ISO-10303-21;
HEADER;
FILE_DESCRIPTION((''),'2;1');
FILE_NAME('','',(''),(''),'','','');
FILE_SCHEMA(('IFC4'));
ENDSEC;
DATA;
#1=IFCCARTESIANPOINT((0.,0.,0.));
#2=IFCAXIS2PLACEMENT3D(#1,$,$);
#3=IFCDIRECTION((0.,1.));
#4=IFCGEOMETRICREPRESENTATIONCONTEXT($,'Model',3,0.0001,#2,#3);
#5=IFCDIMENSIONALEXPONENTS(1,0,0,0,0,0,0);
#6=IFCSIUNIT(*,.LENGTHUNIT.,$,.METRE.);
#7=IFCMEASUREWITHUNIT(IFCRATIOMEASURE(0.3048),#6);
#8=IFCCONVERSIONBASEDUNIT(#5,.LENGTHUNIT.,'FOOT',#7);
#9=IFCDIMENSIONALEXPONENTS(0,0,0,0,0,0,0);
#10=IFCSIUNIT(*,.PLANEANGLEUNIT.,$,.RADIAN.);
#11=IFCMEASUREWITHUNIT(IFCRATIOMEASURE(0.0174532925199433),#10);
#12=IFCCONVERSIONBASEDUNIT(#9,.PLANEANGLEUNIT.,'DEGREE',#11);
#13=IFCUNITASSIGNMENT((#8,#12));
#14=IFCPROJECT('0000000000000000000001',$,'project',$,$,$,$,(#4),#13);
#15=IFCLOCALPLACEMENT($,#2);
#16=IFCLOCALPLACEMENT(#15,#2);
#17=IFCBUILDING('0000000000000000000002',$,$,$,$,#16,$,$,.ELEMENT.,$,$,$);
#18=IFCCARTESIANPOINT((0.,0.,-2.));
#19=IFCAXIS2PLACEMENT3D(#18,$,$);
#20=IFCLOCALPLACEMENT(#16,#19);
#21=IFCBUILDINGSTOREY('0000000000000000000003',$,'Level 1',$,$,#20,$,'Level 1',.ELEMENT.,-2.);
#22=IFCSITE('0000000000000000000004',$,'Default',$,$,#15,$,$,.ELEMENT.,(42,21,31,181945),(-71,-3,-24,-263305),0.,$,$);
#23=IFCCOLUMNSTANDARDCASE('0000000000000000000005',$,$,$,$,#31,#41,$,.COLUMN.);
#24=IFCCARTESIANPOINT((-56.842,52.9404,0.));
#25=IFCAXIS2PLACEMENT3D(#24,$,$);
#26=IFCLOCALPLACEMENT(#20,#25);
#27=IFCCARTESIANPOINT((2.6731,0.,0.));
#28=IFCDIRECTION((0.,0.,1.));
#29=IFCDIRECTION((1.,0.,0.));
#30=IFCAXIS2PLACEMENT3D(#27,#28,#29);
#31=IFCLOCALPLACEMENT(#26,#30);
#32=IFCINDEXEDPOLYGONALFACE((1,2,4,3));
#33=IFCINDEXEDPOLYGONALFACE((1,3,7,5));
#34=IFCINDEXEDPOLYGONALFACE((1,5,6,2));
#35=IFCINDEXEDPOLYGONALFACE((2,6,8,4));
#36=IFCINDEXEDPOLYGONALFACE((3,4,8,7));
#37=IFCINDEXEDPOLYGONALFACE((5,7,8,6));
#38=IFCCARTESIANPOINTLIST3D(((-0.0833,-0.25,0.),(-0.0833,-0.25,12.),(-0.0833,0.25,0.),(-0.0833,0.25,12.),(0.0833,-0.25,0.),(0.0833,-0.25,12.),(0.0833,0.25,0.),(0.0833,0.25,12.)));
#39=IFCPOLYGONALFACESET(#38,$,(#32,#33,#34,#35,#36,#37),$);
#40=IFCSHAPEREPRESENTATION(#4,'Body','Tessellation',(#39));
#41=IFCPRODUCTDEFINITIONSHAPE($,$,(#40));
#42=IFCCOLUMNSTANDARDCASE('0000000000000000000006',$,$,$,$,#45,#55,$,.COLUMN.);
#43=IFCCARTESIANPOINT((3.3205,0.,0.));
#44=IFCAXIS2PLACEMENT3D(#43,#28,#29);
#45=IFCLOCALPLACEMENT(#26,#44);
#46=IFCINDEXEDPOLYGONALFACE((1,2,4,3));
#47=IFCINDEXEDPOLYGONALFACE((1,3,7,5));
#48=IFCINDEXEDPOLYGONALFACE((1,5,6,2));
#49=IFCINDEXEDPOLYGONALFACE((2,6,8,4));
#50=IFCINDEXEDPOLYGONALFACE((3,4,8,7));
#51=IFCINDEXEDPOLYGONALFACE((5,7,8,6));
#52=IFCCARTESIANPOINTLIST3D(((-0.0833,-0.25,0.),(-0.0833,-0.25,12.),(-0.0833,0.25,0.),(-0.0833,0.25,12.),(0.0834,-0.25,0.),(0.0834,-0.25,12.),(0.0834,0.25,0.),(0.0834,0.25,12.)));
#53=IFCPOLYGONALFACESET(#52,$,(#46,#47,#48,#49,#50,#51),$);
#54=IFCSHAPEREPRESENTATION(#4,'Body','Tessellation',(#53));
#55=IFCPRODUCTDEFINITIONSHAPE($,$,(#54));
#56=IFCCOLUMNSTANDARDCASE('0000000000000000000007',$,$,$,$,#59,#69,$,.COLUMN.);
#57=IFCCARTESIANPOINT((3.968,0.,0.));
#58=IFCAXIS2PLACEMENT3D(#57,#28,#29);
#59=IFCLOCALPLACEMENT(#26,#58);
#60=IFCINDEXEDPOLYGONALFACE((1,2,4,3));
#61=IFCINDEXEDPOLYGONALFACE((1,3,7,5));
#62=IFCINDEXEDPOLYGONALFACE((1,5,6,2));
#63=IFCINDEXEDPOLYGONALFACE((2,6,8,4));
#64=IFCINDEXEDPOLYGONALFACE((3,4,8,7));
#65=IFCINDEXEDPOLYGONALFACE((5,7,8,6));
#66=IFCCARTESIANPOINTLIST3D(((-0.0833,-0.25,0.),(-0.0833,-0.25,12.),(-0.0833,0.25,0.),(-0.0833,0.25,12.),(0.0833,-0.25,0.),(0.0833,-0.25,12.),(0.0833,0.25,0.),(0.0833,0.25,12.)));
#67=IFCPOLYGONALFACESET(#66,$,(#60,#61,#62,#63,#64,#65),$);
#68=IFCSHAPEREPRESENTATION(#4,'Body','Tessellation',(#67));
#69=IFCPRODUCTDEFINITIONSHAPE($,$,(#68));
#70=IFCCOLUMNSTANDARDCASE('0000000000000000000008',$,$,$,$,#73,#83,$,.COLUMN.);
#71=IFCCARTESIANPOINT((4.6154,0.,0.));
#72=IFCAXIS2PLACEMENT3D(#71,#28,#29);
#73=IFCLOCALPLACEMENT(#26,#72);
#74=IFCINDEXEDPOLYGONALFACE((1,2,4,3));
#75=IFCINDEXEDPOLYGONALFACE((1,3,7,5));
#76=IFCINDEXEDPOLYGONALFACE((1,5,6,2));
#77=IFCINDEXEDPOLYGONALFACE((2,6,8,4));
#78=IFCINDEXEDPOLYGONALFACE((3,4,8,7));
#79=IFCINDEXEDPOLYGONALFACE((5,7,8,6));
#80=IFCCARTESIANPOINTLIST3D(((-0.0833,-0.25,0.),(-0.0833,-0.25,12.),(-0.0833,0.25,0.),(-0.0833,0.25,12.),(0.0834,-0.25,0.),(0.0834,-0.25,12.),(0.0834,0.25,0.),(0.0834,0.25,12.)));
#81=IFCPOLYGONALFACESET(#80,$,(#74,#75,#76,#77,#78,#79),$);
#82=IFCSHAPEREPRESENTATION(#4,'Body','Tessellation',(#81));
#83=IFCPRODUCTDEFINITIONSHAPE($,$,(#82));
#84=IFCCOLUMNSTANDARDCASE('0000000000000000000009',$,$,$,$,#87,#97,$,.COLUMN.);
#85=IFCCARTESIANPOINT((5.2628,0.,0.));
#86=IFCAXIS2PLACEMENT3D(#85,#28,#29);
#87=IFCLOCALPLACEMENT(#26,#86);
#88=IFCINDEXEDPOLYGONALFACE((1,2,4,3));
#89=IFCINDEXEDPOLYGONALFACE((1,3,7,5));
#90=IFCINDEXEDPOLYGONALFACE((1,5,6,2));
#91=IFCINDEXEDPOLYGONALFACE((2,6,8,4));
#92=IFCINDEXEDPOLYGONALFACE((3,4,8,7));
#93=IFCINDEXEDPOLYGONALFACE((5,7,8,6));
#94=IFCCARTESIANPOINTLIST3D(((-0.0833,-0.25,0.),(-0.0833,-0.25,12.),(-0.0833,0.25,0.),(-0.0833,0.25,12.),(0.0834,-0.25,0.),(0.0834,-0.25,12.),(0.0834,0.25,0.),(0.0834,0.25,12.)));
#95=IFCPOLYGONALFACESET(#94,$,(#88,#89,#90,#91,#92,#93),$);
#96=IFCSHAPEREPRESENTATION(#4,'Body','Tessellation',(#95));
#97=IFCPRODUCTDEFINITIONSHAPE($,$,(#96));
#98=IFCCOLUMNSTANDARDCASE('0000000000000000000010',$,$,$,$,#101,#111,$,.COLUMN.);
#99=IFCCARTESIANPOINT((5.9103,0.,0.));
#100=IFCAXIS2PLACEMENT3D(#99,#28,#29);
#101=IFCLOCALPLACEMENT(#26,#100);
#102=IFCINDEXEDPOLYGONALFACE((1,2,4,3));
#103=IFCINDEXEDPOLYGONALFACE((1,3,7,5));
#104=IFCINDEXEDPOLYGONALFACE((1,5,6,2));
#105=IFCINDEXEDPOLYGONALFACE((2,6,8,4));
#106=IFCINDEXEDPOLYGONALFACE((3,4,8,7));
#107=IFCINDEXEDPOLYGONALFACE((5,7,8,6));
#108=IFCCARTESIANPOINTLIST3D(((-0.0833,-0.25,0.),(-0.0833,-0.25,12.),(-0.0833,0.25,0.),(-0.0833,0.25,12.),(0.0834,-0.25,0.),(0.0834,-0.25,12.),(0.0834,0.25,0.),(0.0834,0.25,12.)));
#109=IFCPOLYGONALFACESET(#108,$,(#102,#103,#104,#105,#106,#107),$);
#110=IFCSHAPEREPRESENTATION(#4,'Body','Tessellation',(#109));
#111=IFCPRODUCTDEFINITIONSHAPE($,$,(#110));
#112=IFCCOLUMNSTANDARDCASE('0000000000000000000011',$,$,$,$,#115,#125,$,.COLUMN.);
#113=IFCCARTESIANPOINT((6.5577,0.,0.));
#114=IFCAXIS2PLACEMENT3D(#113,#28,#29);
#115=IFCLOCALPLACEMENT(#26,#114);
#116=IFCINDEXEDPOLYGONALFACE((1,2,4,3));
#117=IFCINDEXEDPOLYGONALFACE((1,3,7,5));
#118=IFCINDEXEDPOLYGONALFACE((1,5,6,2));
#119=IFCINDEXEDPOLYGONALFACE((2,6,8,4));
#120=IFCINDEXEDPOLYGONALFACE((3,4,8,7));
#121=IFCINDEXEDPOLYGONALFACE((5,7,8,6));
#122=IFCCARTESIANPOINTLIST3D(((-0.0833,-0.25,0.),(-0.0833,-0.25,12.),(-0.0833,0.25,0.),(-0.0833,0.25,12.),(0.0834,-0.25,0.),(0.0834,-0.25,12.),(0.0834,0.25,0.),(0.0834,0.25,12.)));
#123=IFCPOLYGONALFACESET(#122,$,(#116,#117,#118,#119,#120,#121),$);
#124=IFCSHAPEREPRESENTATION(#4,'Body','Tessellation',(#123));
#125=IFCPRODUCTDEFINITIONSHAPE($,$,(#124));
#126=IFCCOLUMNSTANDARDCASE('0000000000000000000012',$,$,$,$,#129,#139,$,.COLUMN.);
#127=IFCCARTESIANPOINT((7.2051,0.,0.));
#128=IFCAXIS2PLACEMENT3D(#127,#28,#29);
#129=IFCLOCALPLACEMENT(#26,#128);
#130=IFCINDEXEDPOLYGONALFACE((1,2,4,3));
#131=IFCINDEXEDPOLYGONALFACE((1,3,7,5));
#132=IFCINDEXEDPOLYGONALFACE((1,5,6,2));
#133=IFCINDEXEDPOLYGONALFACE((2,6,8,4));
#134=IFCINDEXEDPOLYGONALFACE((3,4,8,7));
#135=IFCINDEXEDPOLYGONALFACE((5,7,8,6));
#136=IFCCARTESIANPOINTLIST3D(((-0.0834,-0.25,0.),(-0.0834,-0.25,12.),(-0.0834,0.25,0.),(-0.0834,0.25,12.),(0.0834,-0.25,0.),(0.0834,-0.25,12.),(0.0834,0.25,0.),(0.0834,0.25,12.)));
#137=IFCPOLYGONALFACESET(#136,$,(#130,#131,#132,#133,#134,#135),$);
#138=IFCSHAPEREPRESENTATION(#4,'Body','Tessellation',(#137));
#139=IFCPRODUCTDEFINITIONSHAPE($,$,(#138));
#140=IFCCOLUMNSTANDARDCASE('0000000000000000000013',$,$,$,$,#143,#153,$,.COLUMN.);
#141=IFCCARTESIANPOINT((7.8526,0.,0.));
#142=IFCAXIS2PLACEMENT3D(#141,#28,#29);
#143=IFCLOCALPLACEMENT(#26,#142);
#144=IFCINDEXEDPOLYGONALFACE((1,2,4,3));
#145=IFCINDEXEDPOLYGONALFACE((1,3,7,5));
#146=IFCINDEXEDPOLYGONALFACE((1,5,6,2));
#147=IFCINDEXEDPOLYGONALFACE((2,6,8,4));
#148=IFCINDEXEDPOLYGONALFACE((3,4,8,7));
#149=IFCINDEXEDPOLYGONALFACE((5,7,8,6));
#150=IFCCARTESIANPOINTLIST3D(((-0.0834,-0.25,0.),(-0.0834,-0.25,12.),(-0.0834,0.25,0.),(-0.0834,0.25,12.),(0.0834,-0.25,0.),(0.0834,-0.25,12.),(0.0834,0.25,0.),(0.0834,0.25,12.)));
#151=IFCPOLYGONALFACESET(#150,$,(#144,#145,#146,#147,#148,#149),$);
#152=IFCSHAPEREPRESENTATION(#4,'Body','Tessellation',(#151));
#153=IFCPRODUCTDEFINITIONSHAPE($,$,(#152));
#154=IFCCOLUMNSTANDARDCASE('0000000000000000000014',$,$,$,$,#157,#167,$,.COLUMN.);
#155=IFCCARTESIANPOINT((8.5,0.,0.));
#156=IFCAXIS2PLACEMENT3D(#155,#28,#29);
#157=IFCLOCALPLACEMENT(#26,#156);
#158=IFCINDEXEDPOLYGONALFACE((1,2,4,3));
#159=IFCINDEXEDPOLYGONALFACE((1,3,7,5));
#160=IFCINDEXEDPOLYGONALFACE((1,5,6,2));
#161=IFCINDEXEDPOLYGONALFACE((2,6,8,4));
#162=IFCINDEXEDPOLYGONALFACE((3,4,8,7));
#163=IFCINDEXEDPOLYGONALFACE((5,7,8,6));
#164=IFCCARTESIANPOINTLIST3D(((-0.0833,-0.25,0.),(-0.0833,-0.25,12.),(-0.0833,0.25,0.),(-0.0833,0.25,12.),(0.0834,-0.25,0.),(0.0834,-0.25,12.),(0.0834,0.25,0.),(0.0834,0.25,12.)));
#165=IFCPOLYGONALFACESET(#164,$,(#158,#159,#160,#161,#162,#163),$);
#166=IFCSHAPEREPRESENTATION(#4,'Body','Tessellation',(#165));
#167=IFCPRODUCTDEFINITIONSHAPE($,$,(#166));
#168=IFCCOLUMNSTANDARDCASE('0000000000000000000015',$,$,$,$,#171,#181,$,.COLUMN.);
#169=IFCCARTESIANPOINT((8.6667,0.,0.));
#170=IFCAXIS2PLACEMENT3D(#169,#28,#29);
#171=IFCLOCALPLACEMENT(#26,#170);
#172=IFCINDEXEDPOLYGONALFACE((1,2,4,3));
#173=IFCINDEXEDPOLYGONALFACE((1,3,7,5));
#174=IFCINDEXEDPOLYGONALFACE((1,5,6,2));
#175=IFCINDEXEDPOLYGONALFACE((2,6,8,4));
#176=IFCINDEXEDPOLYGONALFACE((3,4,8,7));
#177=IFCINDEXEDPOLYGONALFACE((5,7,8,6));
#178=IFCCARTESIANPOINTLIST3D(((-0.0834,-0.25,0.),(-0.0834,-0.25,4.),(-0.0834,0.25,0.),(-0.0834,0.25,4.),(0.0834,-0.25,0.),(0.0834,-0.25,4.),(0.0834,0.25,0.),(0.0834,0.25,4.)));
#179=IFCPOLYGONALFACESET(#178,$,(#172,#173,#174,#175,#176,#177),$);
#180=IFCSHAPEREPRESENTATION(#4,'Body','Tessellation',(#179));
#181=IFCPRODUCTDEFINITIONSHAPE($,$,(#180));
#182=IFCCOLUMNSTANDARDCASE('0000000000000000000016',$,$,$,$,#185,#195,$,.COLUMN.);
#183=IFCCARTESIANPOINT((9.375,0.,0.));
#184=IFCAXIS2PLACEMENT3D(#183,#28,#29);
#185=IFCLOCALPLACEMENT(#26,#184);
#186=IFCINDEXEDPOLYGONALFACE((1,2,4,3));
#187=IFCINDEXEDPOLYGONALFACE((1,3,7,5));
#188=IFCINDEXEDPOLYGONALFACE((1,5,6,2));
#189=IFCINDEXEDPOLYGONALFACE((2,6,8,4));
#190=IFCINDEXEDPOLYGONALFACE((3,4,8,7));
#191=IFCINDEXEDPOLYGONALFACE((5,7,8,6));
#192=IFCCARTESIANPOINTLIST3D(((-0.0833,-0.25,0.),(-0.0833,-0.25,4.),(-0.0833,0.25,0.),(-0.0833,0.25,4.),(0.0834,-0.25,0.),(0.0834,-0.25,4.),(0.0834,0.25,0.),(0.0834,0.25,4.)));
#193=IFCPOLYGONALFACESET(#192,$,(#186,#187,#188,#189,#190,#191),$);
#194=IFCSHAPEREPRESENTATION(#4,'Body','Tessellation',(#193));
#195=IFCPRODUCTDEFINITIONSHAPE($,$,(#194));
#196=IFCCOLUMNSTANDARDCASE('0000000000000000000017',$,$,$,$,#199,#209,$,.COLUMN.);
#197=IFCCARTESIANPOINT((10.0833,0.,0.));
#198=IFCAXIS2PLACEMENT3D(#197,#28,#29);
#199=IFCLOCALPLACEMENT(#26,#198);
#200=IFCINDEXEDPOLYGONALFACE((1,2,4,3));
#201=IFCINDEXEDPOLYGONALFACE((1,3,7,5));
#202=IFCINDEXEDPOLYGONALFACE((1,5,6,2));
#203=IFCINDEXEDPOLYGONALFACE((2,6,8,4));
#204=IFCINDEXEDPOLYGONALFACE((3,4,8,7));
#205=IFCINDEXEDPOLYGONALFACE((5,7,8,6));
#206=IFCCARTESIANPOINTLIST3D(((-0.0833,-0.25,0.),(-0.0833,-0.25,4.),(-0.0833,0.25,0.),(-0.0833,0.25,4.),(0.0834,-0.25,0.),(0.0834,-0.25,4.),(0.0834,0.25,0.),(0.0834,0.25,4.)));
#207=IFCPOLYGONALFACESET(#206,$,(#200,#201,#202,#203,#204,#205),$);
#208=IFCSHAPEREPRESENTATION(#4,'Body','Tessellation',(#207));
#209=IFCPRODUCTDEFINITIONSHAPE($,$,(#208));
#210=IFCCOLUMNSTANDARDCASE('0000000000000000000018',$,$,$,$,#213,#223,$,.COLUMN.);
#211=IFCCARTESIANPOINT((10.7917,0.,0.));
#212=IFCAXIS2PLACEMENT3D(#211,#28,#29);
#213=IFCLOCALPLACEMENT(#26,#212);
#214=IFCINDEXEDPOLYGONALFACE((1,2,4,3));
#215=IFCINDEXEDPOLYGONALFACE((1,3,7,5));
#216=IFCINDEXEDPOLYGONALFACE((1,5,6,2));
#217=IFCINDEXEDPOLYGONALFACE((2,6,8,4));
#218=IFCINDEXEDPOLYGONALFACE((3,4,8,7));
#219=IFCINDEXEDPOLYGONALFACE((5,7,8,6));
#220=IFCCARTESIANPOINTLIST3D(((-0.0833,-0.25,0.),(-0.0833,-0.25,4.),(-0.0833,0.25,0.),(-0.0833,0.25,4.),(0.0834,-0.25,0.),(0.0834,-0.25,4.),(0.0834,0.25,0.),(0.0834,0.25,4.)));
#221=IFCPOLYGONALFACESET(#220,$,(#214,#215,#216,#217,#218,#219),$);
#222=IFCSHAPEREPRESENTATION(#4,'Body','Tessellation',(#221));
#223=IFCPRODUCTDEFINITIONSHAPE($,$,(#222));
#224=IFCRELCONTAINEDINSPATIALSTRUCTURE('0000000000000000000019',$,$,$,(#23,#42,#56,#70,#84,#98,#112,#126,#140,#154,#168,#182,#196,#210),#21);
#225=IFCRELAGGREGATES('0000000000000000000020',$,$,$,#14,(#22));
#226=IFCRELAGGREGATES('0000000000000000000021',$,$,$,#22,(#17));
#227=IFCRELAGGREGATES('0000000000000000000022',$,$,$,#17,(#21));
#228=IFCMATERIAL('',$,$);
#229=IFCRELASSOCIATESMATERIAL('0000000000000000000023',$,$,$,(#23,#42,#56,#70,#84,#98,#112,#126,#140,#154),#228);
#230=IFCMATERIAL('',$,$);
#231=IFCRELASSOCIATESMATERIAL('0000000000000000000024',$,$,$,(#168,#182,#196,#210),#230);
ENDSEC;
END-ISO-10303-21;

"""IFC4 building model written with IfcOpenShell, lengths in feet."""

from ifc_helpers import new_model, entity, si_unit, converted_unit, direction, frame, origin, place, context, project, spatial, rectangle, extrude, material, element, save


model = new_model("IFC4")

# Units and contexts
model_context = context("Model", 3, precision=0.0001, world=origin(), true_north=direction((0.0, 1.0)))
ifc_project = project(units=[converted_unit("LENGTHUNIT", "FOOT", entity("IfcRatioMeasure", 0.3048), si_unit("LENGTHUNIT", "METRE"), dimensions=[1, 0, 0, 0, 0, 0, 0]), converted_unit("PLANEANGLEUNIT", "DEGREE", entity("IfcRatioMeasure", 0.0174532925199433), si_unit("PLANEANGLEUNIT", "RADIAN"), dimensions=[0, 0, 0, 0, 0, 0, 0])], contexts=[model_context])

# Site, building, storey
site_placement = place(None, origin())
site = spatial("IfcSite", under=ifc_project, at=site_placement, Name="Default", CompositionType="ELEMENT", RefLatitude=(42, 21, 31, 181945), RefLongitude=(-71, -3, -24, -263305), RefElevation=0.0)
building_placement = place(site_placement, origin())
building = spatial("IfcBuilding", under=site, at=building_placement, CompositionType="ELEMENT")
storey_placement = place(building_placement, frame((0.0, 0.0, -2.0)))
storey = spatial("IfcBuildingStorey", under=building, at=storey_placement, Name="Level 1", LongName="Level 1", CompositionType="ELEMENT", Elevation=-2.0)

# Columns
ifc_material_1 = material(Name="")
placement = place(storey_placement, frame((-56.842, 52.9404, 0.0)))
for number, where, z_axis, x_axis in (
    (1, (2.6731, 0.0, 0.0), (0.0, 0.0, 1.0), (1.0, 0.0, 0.0)),
    (2, (3.3205, 0.0, 0.0), (0.0, 0.0, 1.0), (1.0, 0.0, 0.0)),
    (3, (3.968, 0.0, 0.0), (0.0, 0.0, 1.0), (1.0, 0.0, 0.0)),
    (4, (4.6154, 0.0, 0.0), (0.0, 0.0, 1.0), (1.0, 0.0, 0.0)),
    (5, (5.2628, 0.0, 0.0), (0.0, 0.0, 1.0), (1.0, 0.0, 0.0)),
    (6, (5.9103, 0.0, 0.0), (0.0, 0.0, 1.0), (1.0, 0.0, 0.0)),
    (7, (6.5577, 0.0, 0.0), (0.0, 0.0, 1.0), (1.0, 0.0, 0.0)),
    (8, (7.2051, 0.0, 0.0), (0.0, 0.0, 1.0), (1.0, 0.0, 0.0)),
    (9, (7.8526, 0.0, 0.0), (0.0, 0.0, 1.0), (1.0, 0.0, 0.0)),
    (10, (8.5, 0.0, 0.0), (0.0, 0.0, 1.0), (1.0, 0.0, 0.0)),
):
    element("IfcColumnStandardCase", number, at=place(placement, frame(where, z_axis=z_axis, x_axis=x_axis)), inside=storey, material=ifc_material_1, PredefinedType="COLUMN", context=model_context, shape_type="SweptSolid", body=[
        extrude(rectangle(XDim=0.1667, YDim=0.5), origin(), (0.0, 0.0, 1.0), 12.0),
    ])
ifc_material_2 = material(Name="")
for number, where, z_axis, x_axis in (
    (11, (8.6667, 0.0, 0.0), (0.0, 0.0, 1.0), (1.0, 0.0, 0.0)),
    (12, (9.375, 0.0, 0.0), (0.0, 0.0, 1.0), (1.0, 0.0, 0.0)),
    (13, (10.0833, 0.0, 0.0), (0.0, 0.0, 1.0), (1.0, 0.0, 0.0)),
    (14, (10.7917, 0.0, 0.0), (0.0, 0.0, 1.0), (1.0, 0.0, 0.0)),
):
    element("IfcColumnStandardCase", number, at=place(placement, frame(where, z_axis=z_axis, x_axis=x_axis)), inside=storey, material=ifc_material_2, PredefinedType="COLUMN", context=model_context, shape_type="SweptSolid", body=[
        extrude(rectangle(XDim=0.1667, YDim=0.5), origin(), (0.0, 0.0, 1.0), 4.0),
    ])

save(model, "model.ifc")
